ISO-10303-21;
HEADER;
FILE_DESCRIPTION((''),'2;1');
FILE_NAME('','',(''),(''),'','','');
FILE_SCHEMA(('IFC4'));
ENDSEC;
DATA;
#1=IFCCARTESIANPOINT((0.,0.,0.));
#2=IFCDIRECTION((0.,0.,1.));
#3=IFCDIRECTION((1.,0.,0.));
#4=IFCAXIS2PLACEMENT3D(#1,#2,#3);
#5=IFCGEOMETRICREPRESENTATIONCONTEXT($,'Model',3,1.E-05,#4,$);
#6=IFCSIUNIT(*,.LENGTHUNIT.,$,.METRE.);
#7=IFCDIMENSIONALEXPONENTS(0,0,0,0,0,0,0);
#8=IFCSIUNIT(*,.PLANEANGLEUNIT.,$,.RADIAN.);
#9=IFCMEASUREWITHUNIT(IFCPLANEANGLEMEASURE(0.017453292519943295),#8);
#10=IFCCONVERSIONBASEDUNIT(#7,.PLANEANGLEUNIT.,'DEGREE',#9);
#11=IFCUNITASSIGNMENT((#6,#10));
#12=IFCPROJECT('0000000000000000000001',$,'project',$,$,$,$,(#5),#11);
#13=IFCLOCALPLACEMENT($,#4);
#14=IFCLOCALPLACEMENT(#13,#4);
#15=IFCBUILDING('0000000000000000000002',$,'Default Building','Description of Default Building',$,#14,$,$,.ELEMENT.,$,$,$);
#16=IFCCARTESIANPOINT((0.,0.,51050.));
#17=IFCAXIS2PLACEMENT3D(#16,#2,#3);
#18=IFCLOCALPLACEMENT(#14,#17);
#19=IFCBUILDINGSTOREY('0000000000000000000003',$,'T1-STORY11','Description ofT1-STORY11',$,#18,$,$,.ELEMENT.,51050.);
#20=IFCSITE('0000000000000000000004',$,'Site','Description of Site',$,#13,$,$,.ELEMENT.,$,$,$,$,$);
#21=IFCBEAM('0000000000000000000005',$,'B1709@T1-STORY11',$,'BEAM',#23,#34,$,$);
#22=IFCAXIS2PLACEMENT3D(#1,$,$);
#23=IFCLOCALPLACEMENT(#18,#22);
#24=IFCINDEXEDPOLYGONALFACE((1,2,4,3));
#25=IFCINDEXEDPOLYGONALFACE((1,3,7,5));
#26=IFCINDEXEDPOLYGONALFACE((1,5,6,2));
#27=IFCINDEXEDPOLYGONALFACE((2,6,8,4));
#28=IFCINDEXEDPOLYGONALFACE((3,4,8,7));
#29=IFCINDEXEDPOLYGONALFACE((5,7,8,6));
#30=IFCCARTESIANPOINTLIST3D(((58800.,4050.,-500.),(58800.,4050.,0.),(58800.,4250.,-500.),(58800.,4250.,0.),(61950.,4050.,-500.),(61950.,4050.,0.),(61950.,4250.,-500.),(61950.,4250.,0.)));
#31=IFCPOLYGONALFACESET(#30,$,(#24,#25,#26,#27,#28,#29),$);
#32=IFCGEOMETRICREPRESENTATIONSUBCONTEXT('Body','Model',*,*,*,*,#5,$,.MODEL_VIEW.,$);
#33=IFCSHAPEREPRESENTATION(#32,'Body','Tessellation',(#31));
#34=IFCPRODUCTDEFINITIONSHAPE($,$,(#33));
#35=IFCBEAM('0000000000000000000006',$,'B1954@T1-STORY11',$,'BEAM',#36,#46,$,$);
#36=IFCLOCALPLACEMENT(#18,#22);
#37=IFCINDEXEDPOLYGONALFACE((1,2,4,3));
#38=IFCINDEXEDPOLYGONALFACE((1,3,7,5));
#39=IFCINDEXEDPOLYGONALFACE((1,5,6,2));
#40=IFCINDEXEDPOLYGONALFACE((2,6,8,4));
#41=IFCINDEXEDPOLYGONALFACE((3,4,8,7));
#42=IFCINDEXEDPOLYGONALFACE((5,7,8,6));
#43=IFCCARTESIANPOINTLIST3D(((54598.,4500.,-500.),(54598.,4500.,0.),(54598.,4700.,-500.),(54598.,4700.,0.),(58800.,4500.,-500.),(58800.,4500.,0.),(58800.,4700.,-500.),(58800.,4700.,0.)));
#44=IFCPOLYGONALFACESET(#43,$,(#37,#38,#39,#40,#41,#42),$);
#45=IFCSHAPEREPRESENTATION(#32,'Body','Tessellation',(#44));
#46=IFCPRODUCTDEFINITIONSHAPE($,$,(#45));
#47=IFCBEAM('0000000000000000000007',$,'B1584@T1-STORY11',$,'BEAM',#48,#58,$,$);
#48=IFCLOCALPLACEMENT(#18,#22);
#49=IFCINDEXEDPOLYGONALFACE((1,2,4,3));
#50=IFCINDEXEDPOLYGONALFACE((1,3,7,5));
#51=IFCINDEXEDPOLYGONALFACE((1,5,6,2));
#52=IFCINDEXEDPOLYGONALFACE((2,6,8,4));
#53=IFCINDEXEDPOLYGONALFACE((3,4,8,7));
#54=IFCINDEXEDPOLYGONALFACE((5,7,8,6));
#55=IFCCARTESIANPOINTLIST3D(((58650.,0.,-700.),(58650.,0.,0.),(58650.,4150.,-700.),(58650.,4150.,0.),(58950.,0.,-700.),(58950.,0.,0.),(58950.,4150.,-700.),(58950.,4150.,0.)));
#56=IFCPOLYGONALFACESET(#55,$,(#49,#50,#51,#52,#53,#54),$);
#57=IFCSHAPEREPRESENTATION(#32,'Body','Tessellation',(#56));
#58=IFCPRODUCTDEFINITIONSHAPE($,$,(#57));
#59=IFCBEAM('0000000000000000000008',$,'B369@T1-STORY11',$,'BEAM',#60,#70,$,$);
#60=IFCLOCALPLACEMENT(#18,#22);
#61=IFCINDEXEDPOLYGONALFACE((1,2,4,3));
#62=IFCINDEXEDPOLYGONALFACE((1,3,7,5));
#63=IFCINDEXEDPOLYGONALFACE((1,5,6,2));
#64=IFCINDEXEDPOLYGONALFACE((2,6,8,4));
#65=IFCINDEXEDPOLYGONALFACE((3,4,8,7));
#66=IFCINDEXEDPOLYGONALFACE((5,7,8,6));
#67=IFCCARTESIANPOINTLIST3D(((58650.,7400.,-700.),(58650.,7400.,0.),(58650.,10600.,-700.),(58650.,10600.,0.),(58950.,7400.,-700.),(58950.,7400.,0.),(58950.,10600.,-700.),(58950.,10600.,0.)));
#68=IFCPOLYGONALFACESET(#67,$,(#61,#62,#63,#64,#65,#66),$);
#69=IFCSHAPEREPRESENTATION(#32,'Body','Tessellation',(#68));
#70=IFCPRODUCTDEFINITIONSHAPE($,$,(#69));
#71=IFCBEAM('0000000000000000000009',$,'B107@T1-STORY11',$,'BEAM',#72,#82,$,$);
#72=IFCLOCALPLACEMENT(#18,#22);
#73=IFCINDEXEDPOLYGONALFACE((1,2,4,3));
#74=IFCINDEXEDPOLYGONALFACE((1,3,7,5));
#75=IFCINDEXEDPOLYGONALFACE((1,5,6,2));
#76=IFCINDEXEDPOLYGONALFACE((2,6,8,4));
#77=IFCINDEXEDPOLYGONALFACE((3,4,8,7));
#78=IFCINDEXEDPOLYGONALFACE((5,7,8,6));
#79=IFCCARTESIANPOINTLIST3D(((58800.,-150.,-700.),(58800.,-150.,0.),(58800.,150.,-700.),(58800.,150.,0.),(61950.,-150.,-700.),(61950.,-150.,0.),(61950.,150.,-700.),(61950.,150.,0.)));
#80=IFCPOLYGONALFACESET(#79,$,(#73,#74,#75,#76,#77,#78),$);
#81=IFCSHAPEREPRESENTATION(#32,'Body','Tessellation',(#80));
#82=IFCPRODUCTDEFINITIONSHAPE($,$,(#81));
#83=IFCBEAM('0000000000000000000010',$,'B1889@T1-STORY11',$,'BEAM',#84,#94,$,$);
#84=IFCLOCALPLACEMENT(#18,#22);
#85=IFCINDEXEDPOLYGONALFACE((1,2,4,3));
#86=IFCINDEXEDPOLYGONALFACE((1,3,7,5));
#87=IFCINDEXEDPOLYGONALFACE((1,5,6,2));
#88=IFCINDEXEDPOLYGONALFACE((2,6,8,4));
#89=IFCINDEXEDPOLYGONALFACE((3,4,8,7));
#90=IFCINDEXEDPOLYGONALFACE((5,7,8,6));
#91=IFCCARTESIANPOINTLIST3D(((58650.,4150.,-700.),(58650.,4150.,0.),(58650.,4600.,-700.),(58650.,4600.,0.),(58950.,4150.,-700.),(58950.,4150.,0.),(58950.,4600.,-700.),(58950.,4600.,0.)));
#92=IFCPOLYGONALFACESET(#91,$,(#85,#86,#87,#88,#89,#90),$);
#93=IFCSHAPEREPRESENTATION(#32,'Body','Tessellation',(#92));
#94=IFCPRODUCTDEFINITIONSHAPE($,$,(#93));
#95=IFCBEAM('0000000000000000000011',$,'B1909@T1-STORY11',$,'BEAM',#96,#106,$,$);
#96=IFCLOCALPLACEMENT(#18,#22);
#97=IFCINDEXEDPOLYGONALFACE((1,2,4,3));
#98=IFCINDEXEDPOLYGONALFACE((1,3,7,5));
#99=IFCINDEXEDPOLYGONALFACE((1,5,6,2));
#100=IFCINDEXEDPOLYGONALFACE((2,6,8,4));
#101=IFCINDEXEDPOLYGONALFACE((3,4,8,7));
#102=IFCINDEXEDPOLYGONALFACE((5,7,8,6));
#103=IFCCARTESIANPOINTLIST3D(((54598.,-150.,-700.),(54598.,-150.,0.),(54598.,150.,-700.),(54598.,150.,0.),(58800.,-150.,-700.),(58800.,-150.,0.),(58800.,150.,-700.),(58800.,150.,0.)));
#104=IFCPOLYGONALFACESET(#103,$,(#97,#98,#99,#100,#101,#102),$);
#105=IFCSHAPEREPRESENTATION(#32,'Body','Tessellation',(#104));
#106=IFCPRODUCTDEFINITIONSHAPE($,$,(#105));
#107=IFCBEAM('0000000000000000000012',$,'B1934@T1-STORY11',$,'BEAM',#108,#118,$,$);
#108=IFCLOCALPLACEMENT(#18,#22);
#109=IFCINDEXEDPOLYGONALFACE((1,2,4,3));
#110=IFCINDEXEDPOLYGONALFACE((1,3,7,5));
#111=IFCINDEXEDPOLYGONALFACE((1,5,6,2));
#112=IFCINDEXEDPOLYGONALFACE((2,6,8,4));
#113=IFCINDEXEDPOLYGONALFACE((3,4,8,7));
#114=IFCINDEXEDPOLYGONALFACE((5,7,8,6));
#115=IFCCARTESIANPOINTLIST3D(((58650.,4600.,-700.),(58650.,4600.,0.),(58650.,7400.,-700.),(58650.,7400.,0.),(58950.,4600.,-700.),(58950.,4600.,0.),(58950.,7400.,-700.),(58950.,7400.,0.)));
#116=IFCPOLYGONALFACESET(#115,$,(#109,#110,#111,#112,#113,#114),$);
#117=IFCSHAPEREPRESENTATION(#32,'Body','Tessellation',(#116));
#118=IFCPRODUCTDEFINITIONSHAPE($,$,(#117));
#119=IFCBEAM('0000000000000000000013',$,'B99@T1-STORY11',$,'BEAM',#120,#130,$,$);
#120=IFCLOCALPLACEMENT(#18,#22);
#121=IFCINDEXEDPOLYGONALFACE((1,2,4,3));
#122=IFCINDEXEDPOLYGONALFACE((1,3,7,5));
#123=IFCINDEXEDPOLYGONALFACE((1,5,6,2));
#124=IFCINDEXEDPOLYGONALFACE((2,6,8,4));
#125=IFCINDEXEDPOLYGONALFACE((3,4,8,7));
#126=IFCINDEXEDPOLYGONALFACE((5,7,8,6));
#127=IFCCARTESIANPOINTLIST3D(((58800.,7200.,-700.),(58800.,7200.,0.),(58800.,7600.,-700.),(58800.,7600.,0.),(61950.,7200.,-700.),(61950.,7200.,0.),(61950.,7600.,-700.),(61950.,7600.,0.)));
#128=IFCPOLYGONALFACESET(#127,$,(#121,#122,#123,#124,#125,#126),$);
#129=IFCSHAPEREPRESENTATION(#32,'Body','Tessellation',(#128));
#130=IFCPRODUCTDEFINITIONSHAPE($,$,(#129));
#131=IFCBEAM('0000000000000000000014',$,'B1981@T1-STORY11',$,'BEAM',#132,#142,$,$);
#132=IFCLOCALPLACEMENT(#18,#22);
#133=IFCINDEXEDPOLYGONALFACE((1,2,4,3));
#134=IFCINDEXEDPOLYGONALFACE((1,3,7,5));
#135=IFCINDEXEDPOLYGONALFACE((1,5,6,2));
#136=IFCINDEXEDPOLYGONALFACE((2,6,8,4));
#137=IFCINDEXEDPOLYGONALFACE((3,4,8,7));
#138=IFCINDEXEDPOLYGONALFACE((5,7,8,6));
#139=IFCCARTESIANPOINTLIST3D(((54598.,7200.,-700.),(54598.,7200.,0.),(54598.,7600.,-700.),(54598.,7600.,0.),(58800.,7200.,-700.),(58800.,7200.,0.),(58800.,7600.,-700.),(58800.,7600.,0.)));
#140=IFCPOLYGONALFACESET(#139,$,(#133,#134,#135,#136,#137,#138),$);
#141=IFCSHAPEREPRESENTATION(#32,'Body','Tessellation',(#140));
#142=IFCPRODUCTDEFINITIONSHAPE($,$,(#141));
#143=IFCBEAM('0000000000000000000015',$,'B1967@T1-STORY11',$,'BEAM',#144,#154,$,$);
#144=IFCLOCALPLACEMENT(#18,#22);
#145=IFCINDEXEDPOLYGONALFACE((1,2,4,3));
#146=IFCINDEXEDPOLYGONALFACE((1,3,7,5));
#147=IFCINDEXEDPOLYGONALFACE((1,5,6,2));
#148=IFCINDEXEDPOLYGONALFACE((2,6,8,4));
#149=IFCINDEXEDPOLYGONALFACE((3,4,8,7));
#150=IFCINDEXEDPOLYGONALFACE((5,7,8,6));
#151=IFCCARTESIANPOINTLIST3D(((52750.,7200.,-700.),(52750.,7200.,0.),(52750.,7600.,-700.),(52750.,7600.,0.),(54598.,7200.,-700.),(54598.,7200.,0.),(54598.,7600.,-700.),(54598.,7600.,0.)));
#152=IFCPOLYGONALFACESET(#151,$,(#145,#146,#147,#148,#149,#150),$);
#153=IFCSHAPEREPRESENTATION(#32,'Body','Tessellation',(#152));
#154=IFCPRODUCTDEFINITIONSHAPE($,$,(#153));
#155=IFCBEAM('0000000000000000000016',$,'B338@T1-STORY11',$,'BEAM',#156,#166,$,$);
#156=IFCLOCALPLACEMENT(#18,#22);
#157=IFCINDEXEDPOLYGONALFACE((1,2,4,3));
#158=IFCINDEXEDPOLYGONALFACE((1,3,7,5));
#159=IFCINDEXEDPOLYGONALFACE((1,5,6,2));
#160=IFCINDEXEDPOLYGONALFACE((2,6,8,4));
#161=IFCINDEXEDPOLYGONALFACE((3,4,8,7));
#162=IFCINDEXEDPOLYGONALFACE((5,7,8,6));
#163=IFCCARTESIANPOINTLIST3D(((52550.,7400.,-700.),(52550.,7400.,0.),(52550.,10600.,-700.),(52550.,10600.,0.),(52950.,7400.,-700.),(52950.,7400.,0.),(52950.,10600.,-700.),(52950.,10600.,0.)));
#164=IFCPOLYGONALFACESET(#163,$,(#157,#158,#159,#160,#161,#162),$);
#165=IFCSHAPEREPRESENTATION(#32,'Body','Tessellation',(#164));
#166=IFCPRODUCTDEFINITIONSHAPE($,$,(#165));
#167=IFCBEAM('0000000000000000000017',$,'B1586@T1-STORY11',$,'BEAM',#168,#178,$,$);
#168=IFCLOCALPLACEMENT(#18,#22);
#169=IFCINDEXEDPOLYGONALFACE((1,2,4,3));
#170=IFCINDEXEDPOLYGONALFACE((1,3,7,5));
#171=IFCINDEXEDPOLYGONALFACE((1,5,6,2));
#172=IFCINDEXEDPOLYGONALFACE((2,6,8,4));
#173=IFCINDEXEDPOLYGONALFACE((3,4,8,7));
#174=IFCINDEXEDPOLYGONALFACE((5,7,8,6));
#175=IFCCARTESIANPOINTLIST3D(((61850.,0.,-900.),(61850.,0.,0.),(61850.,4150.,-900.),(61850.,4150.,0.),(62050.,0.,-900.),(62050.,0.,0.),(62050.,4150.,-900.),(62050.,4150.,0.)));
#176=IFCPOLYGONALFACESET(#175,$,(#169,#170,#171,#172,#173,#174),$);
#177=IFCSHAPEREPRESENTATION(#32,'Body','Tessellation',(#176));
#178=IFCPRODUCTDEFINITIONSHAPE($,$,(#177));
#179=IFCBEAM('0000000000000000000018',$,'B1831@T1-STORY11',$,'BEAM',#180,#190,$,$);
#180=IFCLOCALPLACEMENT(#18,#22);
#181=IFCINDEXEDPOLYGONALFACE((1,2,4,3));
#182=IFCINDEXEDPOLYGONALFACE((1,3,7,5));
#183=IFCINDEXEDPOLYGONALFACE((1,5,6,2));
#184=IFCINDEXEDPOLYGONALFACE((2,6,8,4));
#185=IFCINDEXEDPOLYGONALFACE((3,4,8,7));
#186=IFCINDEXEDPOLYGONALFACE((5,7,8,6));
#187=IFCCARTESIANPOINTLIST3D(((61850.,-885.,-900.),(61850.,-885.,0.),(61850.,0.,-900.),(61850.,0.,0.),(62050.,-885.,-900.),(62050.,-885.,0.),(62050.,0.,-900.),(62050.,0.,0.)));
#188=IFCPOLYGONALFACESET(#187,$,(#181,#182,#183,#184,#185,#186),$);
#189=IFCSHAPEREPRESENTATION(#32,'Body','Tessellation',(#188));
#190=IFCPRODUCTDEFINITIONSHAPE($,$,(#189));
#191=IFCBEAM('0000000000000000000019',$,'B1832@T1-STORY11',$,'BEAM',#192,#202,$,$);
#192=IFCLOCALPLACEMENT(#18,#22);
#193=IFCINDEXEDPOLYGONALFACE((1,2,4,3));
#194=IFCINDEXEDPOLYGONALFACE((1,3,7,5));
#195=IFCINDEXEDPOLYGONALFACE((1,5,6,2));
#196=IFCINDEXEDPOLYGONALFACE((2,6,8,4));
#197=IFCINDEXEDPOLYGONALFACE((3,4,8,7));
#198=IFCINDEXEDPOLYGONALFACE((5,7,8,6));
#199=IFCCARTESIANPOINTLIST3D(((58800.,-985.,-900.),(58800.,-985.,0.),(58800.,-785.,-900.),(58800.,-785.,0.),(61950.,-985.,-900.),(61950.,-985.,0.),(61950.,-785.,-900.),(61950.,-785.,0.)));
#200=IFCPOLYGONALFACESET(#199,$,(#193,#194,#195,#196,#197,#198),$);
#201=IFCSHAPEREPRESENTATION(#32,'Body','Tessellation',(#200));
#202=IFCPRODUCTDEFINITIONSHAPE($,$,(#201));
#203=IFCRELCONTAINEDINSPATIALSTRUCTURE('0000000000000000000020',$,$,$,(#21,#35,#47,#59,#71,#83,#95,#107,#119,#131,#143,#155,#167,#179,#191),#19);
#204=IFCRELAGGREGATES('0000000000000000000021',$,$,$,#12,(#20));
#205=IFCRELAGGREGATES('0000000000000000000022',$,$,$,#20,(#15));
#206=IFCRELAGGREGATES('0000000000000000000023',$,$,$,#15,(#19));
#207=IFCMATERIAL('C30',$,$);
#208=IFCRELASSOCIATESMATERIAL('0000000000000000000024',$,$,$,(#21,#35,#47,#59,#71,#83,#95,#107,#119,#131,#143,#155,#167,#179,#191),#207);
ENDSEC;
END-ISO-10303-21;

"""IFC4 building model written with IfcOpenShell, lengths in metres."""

from ifc_helpers import new_model, entity, si_unit, converted_unit, frame, origin_with_axes, place, context, subcontext, project, spatial, rectangle, extrude, material, element, save


model = new_model("IFC4")

# Units and contexts
model_context = context("Model", 3, precision=1e-05, world=origin_with_axes())
body_context = subcontext(model_context, "Body", "Model", "MODEL_VIEW")
ifc_project = project(units=[si_unit("LENGTHUNIT", "METRE"), converted_unit("PLANEANGLEUNIT", "DEGREE", entity("IfcPlaneAngleMeasure", 0.017453292519943295), si_unit("PLANEANGLEUNIT", "RADIAN"), dimensions=[0, 0, 0, 0, 0, 0, 0])], contexts=[model_context])

# Site, building, storey
site_placement = place(None, origin_with_axes())
site = spatial("IfcSite", under=ifc_project, at=site_placement, Name="Site", Description="Description of Site", CompositionType="ELEMENT")
building_placement = place(site_placement, origin_with_axes())
building = spatial("IfcBuilding", under=site, at=building_placement, Name="Default Building", Description="Description of Default Building", CompositionType="ELEMENT")
storey_placement = place(building_placement, frame((0.0, 0.0, 51050.0), z_axis=(0.0, 0.0, 1.0), x_axis=(1.0, 0.0, 0.0)))
storey = spatial("IfcBuildingStorey", under=building, at=storey_placement, Name="T1-STORY11", Description="Description ofT1-STORY11", CompositionType="ELEMENT", Elevation=51050.0)

# Beams
ifc_material_1 = material(Name="C30")
beam_1_placement = place(storey_placement, frame((58800.0, 4150.0, -250.0), z_axis=(1.0, 0.0, 0.0), x_axis=(0.0, 1.0, 0.0)))
element("IfcBeam", 1, at=beam_1_placement, inside=storey, material=ifc_material_1, Name="B1709@T1-STORY11", ObjectType="BEAM", context=body_context, shape_type="SweptSolid", body=[
    extrude(rectangle(XDim=200.0, YDim=500.0), origin_with_axes(), (0.0, 0.0, 1.0), 3150.0),
])
beam_2_placement = place(storey_placement, frame((54598.0, 4600.0, -250.0), z_axis=(1.0, 0.0, 0.0), x_axis=(0.0, 1.0, 0.0)))
element("IfcBeam", 2, at=beam_2_placement, inside=storey, material=ifc_material_1, Name="B1954@T1-STORY11", ObjectType="BEAM", context=body_context, shape_type="SweptSolid", body=[
    extrude(rectangle(XDim=200.0, YDim=500.0), origin_with_axes(), (0.0, 0.0, 1.0), 4202.0),
])
beam_3_placement = place(storey_placement, frame((58800.0, 0.0, -350.0), z_axis=(0.0, 1.0, 0.0), x_axis=(-1.0, 0.0, 0.0)))
element("IfcBeam", 3, at=beam_3_placement, inside=storey, material=ifc_material_1, Name="B1584@T1-STORY11", ObjectType="BEAM", context=body_context, shape_type="SweptSolid", body=[
    extrude(rectangle(XDim=300.0, YDim=700.0), origin_with_axes(), (0.0, 0.0, 1.0), 4150.0),
])
beam_4_placement = place(storey_placement, frame((58800.0, 7400.0, -350.0), z_axis=(0.0, 1.0, 0.0), x_axis=(-1.0, 0.0, 0.0)))
element("IfcBeam", 4, at=beam_4_placement, inside=storey, material=ifc_material_1, Name="B369@T1-STORY11", ObjectType="BEAM", context=body_context, shape_type="SweptSolid", body=[
    extrude(rectangle(XDim=300.0, YDim=700.0), origin_with_axes(), (0.0, 0.0, 1.0), 3200.0),
])
beam_5_placement = place(storey_placement, frame((58800.0, 0.0, -350.0), z_axis=(1.0, 0.0, 0.0), x_axis=(0.0, 1.0, 0.0)))
element("IfcBeam", 5, at=beam_5_placement, inside=storey, material=ifc_material_1, Name="B107@T1-STORY11", ObjectType="BEAM", context=body_context, shape_type="SweptSolid", body=[
    extrude(rectangle(XDim=300.0, YDim=700.0), origin_with_axes(), (0.0, 0.0, 1.0), 3150.0),
])
beam_6_placement = place(storey_placement, frame((58800.0, 4150.0, -350.0), z_axis=(0.0, 1.0, 0.0), x_axis=(-1.0, 0.0, 0.0)))
element("IfcBeam", 6, at=beam_6_placement, inside=storey, material=ifc_material_1, Name="B1889@T1-STORY11", ObjectType="BEAM", context=body_context, shape_type="SweptSolid", body=[
    extrude(rectangle(XDim=300.0, YDim=700.0), origin_with_axes(), (0.0, 0.0, 1.0), 450.0),
])
beam_7_placement = place(storey_placement, frame((54598.0, 0.0, -350.0), z_axis=(1.0, 0.0, 0.0), x_axis=(0.0, 1.0, 0.0)))
element("IfcBeam", 7, at=beam_7_placement, inside=storey, material=ifc_material_1, Name="B1909@T1-STORY11", ObjectType="BEAM", context=body_context, shape_type="SweptSolid", body=[
    extrude(rectangle(XDim=300.0, YDim=700.0), origin_with_axes(), (0.0, 0.0, 1.0), 4202.0),
])
beam_8_placement = place(storey_placement, frame((58800.0, 4600.0, -350.0), z_axis=(0.0, 1.0, 0.0), x_axis=(-1.0, 0.0, 0.0)))
element("IfcBeam", 8, at=beam_8_placement, inside=storey, material=ifc_material_1, Name="B1934@T1-STORY11", ObjectType="BEAM", context=body_context, shape_type="SweptSolid", body=[
    extrude(rectangle(XDim=300.0, YDim=700.0), origin_with_axes(), (0.0, 0.0, 1.0), 2800.0),
])
beam_9_placement = place(storey_placement, frame((58800.0, 7400.0, -350.0), z_axis=(1.0, 0.0, 0.0), x_axis=(0.0, 1.0, 0.0)))
element("IfcBeam", 9, at=beam_9_placement, inside=storey, material=ifc_material_1, Name="B99@T1-STORY11", ObjectType="BEAM", context=body_context, shape_type="SweptSolid", body=[
    extrude(rectangle(XDim=400.0, YDim=700.0), origin_with_axes(), (0.0, 0.0, 1.0), 3150.0),
])
beam_10_placement = place(storey_placement, frame((54598.0, 7400.0, -350.0), z_axis=(1.0, 0.0, 0.0), x_axis=(0.0, 1.0, 0.0)))
element("IfcBeam", 10, at=beam_10_placement, inside=storey, material=ifc_material_1, Name="B1981@T1-STORY11", ObjectType="BEAM", context=body_context, shape_type="SweptSolid", body=[
    extrude(rectangle(XDim=400.0, YDim=700.0), origin_with_axes(), (0.0, 0.0, 1.0), 4202.0),
])
beam_11_placement = place(storey_placement, frame((52750.0, 7400.0, -350.0), z_axis=(1.0, 0.0, 0.0), x_axis=(0.0, 1.0, 0.0)))
element("IfcBeam", 11, at=beam_11_placement, inside=storey, material=ifc_material_1, Name="B1967@T1-STORY11", ObjectType="BEAM", context=body_context, shape_type="SweptSolid", body=[
    extrude(rectangle(XDim=400.0, YDim=700.0), origin_with_axes(), (0.0, 0.0, 1.0), 1848.0),
])
beam_12_placement = place(storey_placement, frame((52750.0, 7400.0, -350.0), z_axis=(0.0, 1.0, 0.0), x_axis=(-1.0, 0.0, 0.0)))
element("IfcBeam", 12, at=beam_12_placement, inside=storey, material=ifc_material_1, Name="B338@T1-STORY11", ObjectType="BEAM", context=body_context, shape_type="SweptSolid", body=[
    extrude(rectangle(XDim=400.0, YDim=700.0), origin_with_axes(), (0.0, 0.0, 1.0), 3200.0),
])
beam_13_placement = place(storey_placement, frame((61950.0, 0.0, -450.0), z_axis=(0.0, 1.0, 0.0), x_axis=(-1.0, 0.0, 0.0)))
element("IfcBeam", 13, at=beam_13_placement, inside=storey, material=ifc_material_1, Name="B1586@T1-STORY11", ObjectType="BEAM", context=body_context, shape_type="SweptSolid", body=[
    extrude(rectangle(XDim=200.0, YDim=900.0), origin_with_axes(), (0.0, 0.0, 1.0), 4150.0),
])
beam_14_placement = place(storey_placement, frame((61950.0, -885.0, -450.0), z_axis=(0.0, 1.0, 0.0), x_axis=(-1.0, 0.0, 0.0)))
element("IfcBeam", 14, at=beam_14_placement, inside=storey, material=ifc_material_1, Name="B1831@T1-STORY11", ObjectType="BEAM", context=body_context, shape_type="SweptSolid", body=[
    extrude(rectangle(XDim=200.0, YDim=900.0), origin_with_axes(), (0.0, 0.0, 1.0), 885.0),
])
beam_15_placement = place(storey_placement, frame((58800.0, -885.0, -450.0), z_axis=(1.0, 0.0, 0.0), x_axis=(0.0, 1.0, 0.0)))
element("IfcBeam", 15, at=beam_15_placement, inside=storey, material=ifc_material_1, Name="B1832@T1-STORY11", ObjectType="BEAM", context=body_context, shape_type="SweptSolid", body=[
    extrude(rectangle(XDim=200.0, YDim=900.0), origin_with_axes(), (0.0, 0.0, 1.0), 3150.0),
])

save(model, "model.ifc")
